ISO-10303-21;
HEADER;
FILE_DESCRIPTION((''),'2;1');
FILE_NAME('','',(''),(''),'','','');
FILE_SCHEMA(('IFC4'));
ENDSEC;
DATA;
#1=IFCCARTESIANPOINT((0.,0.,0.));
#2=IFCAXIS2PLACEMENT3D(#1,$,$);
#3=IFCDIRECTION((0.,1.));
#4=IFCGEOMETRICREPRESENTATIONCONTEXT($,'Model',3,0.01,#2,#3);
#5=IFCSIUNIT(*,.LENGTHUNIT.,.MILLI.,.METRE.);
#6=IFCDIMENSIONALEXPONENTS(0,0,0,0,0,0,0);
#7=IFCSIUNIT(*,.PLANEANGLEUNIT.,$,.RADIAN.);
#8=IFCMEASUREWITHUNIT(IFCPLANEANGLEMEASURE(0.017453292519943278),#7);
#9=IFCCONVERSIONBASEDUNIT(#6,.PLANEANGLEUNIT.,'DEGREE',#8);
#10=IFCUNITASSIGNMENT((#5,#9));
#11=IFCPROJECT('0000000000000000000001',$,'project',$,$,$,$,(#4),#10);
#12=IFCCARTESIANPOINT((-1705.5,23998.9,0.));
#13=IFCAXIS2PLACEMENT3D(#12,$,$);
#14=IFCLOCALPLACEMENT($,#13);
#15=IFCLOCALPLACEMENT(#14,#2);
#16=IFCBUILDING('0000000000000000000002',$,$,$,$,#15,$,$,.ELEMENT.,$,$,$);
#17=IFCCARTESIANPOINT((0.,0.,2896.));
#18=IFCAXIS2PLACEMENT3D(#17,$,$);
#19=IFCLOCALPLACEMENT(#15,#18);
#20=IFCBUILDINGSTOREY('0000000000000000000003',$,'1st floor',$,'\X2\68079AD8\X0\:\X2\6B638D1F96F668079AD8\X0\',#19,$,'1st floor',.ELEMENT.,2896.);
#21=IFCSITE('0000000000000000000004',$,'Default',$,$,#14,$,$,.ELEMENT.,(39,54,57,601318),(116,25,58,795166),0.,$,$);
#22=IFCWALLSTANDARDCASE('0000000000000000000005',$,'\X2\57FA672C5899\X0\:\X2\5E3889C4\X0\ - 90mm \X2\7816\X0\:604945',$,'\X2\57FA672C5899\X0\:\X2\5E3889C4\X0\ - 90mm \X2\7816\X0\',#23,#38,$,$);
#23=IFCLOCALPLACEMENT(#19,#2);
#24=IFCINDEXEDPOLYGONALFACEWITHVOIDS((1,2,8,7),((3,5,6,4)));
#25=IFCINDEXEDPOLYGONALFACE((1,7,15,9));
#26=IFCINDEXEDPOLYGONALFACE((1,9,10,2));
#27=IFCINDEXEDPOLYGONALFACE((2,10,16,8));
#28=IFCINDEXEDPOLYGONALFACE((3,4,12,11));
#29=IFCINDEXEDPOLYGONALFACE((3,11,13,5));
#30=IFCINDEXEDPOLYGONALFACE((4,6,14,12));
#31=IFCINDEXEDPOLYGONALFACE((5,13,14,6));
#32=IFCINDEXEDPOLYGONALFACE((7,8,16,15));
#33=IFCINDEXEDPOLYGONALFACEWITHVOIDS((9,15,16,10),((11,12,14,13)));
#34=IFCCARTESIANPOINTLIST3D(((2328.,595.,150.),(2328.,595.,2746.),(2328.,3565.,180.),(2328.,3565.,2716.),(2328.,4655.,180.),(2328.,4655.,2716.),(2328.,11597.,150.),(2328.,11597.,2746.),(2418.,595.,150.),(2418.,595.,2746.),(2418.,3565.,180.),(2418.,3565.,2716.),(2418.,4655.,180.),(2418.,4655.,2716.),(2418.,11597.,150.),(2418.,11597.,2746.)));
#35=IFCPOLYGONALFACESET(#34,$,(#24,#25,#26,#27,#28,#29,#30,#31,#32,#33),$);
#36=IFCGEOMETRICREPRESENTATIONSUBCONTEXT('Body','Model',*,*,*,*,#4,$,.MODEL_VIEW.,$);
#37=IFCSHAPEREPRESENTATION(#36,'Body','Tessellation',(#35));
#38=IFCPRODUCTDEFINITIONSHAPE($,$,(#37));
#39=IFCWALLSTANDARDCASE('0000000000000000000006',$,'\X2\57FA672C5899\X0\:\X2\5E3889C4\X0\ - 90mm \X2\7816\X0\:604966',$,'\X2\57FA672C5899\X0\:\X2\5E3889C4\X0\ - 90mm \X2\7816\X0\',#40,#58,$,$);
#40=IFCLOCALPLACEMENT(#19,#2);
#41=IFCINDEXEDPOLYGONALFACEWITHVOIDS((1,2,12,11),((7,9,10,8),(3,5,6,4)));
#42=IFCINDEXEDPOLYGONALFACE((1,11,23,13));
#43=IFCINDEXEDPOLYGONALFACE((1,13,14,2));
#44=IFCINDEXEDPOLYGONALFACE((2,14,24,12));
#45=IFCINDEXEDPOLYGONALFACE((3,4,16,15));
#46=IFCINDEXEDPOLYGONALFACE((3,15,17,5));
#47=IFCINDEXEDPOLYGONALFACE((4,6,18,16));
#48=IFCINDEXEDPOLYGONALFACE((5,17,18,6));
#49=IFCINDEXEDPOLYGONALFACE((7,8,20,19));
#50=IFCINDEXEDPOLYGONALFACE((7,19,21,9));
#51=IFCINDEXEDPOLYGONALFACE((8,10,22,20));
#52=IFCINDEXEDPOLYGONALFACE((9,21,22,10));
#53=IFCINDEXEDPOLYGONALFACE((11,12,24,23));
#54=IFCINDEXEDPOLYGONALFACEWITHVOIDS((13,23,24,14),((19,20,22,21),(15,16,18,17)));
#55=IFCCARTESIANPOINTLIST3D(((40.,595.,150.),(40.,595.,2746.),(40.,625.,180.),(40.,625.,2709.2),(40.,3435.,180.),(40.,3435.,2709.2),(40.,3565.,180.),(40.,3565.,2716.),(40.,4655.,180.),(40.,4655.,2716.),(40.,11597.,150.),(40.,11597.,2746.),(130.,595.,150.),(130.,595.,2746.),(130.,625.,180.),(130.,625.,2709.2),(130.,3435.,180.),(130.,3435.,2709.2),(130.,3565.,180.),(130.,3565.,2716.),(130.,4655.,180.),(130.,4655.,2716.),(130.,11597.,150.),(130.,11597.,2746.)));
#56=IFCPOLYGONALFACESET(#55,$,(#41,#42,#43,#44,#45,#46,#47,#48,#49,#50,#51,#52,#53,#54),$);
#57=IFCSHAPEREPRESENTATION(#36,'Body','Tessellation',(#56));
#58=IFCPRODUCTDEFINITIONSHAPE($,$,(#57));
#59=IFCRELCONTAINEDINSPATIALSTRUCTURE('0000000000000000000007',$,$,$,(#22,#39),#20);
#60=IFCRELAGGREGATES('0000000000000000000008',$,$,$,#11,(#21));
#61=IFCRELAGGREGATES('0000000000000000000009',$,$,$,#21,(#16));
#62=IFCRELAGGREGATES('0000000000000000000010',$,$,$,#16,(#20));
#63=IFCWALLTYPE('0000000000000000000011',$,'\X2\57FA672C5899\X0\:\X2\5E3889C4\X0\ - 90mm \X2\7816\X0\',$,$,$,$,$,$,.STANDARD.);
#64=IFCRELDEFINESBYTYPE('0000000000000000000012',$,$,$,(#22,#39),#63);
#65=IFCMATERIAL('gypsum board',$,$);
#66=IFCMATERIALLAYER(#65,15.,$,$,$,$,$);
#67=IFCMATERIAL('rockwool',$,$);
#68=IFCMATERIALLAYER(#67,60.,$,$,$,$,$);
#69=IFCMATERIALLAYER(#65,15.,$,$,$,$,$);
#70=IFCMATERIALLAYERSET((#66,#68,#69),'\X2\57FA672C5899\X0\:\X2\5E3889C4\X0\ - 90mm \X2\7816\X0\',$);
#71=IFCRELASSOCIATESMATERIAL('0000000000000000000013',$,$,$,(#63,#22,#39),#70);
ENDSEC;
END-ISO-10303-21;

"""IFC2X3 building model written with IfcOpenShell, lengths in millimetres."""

from ifc_helpers import new_model, entity, si_unit, converted_unit, direction, frame, frame_2d, origin, place, context, subcontext, project, spatial, rectangle, extrude, material, layer, layer_set, layer_usage, type_object, element, save


model = new_model("IFC2X3")

# Units and contexts
model_context = context("Model", 3, precision=0.01, world=origin(), true_north=direction((0.0, 1.0)))
body_context = subcontext(model_context, "Body", "Model", "MODEL_VIEW")
ifc_project = project(units=[si_unit("LENGTHUNIT", "METRE", prefix="MILLI"), converted_unit("PLANEANGLEUNIT", "DEGREE", entity("IfcPlaneAngleMeasure", 0.017453292519943278), si_unit("PLANEANGLEUNIT", "RADIAN"), dimensions=[0, 0, 0, 0, 0, 0, 0])], contexts=[model_context])

# Site, building, storey
site_placement = place(None, frame((-1705.5, 23998.9, 0.0)))
site = spatial("IfcSite", under=ifc_project, at=site_placement, Name="Default", CompositionType="ELEMENT", RefLatitude=(39, 54, 57, 601318), RefLongitude=(116, 25, 58, 795166), RefElevation=0.0)
building_placement = place(site_placement, origin())
building = spatial("IfcBuilding", under=site, at=building_placement, CompositionType="ELEMENT")
storey_placement = place(building_placement, frame((0.0, 0.0, 2896.0)))
storey = spatial("IfcBuildingStorey", under=building, at=storey_placement, Name="1st floor", ObjectType="标高:正负零标高", LongName="1st floor", CompositionType="ELEMENT", Elevation=2896.0)

# Shared definitions
ifc_material_1 = material(Name="gypsum board")
ifc_layer_1 = layer(ifc_material_1, 15.0)
ifc_material_2 = material(Name="rockwool")
ifc_layer_2 = layer(ifc_material_2, 60.0)
ifc_layer_3 = layer(ifc_material_1, 15.0)
ifc_layer_set = layer_set([ifc_layer_1, ifc_layer_2, ifc_layer_3], Name="基本墙:常规 - 90mm 砖")
wall_type = type_object("IfcWallType", Name="基本墙:常规 - 90mm 砖", PredefinedType="STANDARD", material=ifc_layer_set)

# Wall, opening
ifc_layer_usage_1 = layer_usage(ifc_layer_set, "AXIS2", "NEGATIVE", 45.0)
wall_1_placement = place(storey_placement, frame((2373.0, 11597.0, 150.0), z_axis=(0.0, 0.0, 1.0), x_axis=(0.0, -1.0, 0.0)))
wall_1 = element("IfcWallStandardCase", 1, at=wall_1_placement, inside=storey, type_object=wall_type, material=ifc_layer_usage_1, Name="基本墙:常规 - 90mm 砖:604945", ObjectType="基本墙:常规 - 90mm 砖", context=body_context, shape_type="SweptSolid", body=[
    extrude(rectangle(XDim=11002.0, YDim=90.0, at=frame_2d((5501.0, 0.0), x_axis=(-1.0, 0.0))), origin(), (0.0, 0.0, 1.0), 2596.0),
])
opening_1_placement = place(wall_1_placement, origin())
element("IfcOpeningElement", 2, at=opening_1_placement, cuts=wall_1, ObjectType="Opening", context=body_context, shape_type="SweptSolid", body=[
    extrude(rectangle(XDim=2536.0, YDim=1090.0, at=frame_2d((0.0, 0.0), x_axis=(0.0, 1.0))), frame((7487.0, 45.0, 1298.0), z_axis=(0.0, -1.0, 0.0), x_axis=(-1.0, 0.0, 0.0)), (0.0, 0.0, 1.0), 90.0),
])

# Wall, openings
ifc_layer_usage_2 = layer_usage(ifc_layer_set, "AXIS2", "NEGATIVE", 45.0)
wall_2_placement = place(storey_placement, frame((85.0, 11597.0, 150.0), z_axis=(0.0, 0.0, 1.0), x_axis=(0.0, -1.0, 0.0)))
wall_2 = element("IfcWallStandardCase", 3, at=wall_2_placement, inside=storey, type_object=wall_type, material=ifc_layer_usage_2, Name="基本墙:常规 - 90mm 砖:604966", ObjectType="基本墙:常规 - 90mm 砖", context=body_context, shape_type="SweptSolid", body=[
    extrude(rectangle(XDim=11002.0, YDim=90.0, at=frame_2d((5501.0, 0.0), x_axis=(-1.0, 0.0))), origin(), (0.0, 0.0, 1.0), 2596.0),
])
opening_2_placement = place(wall_2_placement, origin())
element("IfcOpeningElement", 4, at=opening_2_placement, cuts=wall_2, ObjectType="Opening", context=body_context, shape_type="SweptSolid", body=[
    extrude(rectangle(XDim=2536.0, YDim=1090.0, at=frame_2d((0.0, 0.0), x_axis=(0.0, 1.0))), frame((7487.0, 45.0, 1298.0), z_axis=(0.0, -1.0, 0.0), x_axis=(-1.0, 0.0, 0.0)), (0.0, 0.0, 1.0), 90.0),
])
opening_3_placement = place(wall_2_placement, origin())
element("IfcOpeningElement", 5, at=opening_3_placement, cuts=wall_2, ObjectType="Opening", context=body_context, shape_type="SweptSolid", body=[
    extrude(rectangle(XDim=2529.2, YDim=2810.0, at=frame_2d((0.0, 0.0), x_axis=(0.0, 1.0))), frame((9567.0, 45.0, 1294.6), z_axis=(0.0, -1.0, 0.0), x_axis=(-1.0, 0.0, 0.0)), (0.0, 0.0, 1.0), 90.0),
])

save(model, "model.ifc")
